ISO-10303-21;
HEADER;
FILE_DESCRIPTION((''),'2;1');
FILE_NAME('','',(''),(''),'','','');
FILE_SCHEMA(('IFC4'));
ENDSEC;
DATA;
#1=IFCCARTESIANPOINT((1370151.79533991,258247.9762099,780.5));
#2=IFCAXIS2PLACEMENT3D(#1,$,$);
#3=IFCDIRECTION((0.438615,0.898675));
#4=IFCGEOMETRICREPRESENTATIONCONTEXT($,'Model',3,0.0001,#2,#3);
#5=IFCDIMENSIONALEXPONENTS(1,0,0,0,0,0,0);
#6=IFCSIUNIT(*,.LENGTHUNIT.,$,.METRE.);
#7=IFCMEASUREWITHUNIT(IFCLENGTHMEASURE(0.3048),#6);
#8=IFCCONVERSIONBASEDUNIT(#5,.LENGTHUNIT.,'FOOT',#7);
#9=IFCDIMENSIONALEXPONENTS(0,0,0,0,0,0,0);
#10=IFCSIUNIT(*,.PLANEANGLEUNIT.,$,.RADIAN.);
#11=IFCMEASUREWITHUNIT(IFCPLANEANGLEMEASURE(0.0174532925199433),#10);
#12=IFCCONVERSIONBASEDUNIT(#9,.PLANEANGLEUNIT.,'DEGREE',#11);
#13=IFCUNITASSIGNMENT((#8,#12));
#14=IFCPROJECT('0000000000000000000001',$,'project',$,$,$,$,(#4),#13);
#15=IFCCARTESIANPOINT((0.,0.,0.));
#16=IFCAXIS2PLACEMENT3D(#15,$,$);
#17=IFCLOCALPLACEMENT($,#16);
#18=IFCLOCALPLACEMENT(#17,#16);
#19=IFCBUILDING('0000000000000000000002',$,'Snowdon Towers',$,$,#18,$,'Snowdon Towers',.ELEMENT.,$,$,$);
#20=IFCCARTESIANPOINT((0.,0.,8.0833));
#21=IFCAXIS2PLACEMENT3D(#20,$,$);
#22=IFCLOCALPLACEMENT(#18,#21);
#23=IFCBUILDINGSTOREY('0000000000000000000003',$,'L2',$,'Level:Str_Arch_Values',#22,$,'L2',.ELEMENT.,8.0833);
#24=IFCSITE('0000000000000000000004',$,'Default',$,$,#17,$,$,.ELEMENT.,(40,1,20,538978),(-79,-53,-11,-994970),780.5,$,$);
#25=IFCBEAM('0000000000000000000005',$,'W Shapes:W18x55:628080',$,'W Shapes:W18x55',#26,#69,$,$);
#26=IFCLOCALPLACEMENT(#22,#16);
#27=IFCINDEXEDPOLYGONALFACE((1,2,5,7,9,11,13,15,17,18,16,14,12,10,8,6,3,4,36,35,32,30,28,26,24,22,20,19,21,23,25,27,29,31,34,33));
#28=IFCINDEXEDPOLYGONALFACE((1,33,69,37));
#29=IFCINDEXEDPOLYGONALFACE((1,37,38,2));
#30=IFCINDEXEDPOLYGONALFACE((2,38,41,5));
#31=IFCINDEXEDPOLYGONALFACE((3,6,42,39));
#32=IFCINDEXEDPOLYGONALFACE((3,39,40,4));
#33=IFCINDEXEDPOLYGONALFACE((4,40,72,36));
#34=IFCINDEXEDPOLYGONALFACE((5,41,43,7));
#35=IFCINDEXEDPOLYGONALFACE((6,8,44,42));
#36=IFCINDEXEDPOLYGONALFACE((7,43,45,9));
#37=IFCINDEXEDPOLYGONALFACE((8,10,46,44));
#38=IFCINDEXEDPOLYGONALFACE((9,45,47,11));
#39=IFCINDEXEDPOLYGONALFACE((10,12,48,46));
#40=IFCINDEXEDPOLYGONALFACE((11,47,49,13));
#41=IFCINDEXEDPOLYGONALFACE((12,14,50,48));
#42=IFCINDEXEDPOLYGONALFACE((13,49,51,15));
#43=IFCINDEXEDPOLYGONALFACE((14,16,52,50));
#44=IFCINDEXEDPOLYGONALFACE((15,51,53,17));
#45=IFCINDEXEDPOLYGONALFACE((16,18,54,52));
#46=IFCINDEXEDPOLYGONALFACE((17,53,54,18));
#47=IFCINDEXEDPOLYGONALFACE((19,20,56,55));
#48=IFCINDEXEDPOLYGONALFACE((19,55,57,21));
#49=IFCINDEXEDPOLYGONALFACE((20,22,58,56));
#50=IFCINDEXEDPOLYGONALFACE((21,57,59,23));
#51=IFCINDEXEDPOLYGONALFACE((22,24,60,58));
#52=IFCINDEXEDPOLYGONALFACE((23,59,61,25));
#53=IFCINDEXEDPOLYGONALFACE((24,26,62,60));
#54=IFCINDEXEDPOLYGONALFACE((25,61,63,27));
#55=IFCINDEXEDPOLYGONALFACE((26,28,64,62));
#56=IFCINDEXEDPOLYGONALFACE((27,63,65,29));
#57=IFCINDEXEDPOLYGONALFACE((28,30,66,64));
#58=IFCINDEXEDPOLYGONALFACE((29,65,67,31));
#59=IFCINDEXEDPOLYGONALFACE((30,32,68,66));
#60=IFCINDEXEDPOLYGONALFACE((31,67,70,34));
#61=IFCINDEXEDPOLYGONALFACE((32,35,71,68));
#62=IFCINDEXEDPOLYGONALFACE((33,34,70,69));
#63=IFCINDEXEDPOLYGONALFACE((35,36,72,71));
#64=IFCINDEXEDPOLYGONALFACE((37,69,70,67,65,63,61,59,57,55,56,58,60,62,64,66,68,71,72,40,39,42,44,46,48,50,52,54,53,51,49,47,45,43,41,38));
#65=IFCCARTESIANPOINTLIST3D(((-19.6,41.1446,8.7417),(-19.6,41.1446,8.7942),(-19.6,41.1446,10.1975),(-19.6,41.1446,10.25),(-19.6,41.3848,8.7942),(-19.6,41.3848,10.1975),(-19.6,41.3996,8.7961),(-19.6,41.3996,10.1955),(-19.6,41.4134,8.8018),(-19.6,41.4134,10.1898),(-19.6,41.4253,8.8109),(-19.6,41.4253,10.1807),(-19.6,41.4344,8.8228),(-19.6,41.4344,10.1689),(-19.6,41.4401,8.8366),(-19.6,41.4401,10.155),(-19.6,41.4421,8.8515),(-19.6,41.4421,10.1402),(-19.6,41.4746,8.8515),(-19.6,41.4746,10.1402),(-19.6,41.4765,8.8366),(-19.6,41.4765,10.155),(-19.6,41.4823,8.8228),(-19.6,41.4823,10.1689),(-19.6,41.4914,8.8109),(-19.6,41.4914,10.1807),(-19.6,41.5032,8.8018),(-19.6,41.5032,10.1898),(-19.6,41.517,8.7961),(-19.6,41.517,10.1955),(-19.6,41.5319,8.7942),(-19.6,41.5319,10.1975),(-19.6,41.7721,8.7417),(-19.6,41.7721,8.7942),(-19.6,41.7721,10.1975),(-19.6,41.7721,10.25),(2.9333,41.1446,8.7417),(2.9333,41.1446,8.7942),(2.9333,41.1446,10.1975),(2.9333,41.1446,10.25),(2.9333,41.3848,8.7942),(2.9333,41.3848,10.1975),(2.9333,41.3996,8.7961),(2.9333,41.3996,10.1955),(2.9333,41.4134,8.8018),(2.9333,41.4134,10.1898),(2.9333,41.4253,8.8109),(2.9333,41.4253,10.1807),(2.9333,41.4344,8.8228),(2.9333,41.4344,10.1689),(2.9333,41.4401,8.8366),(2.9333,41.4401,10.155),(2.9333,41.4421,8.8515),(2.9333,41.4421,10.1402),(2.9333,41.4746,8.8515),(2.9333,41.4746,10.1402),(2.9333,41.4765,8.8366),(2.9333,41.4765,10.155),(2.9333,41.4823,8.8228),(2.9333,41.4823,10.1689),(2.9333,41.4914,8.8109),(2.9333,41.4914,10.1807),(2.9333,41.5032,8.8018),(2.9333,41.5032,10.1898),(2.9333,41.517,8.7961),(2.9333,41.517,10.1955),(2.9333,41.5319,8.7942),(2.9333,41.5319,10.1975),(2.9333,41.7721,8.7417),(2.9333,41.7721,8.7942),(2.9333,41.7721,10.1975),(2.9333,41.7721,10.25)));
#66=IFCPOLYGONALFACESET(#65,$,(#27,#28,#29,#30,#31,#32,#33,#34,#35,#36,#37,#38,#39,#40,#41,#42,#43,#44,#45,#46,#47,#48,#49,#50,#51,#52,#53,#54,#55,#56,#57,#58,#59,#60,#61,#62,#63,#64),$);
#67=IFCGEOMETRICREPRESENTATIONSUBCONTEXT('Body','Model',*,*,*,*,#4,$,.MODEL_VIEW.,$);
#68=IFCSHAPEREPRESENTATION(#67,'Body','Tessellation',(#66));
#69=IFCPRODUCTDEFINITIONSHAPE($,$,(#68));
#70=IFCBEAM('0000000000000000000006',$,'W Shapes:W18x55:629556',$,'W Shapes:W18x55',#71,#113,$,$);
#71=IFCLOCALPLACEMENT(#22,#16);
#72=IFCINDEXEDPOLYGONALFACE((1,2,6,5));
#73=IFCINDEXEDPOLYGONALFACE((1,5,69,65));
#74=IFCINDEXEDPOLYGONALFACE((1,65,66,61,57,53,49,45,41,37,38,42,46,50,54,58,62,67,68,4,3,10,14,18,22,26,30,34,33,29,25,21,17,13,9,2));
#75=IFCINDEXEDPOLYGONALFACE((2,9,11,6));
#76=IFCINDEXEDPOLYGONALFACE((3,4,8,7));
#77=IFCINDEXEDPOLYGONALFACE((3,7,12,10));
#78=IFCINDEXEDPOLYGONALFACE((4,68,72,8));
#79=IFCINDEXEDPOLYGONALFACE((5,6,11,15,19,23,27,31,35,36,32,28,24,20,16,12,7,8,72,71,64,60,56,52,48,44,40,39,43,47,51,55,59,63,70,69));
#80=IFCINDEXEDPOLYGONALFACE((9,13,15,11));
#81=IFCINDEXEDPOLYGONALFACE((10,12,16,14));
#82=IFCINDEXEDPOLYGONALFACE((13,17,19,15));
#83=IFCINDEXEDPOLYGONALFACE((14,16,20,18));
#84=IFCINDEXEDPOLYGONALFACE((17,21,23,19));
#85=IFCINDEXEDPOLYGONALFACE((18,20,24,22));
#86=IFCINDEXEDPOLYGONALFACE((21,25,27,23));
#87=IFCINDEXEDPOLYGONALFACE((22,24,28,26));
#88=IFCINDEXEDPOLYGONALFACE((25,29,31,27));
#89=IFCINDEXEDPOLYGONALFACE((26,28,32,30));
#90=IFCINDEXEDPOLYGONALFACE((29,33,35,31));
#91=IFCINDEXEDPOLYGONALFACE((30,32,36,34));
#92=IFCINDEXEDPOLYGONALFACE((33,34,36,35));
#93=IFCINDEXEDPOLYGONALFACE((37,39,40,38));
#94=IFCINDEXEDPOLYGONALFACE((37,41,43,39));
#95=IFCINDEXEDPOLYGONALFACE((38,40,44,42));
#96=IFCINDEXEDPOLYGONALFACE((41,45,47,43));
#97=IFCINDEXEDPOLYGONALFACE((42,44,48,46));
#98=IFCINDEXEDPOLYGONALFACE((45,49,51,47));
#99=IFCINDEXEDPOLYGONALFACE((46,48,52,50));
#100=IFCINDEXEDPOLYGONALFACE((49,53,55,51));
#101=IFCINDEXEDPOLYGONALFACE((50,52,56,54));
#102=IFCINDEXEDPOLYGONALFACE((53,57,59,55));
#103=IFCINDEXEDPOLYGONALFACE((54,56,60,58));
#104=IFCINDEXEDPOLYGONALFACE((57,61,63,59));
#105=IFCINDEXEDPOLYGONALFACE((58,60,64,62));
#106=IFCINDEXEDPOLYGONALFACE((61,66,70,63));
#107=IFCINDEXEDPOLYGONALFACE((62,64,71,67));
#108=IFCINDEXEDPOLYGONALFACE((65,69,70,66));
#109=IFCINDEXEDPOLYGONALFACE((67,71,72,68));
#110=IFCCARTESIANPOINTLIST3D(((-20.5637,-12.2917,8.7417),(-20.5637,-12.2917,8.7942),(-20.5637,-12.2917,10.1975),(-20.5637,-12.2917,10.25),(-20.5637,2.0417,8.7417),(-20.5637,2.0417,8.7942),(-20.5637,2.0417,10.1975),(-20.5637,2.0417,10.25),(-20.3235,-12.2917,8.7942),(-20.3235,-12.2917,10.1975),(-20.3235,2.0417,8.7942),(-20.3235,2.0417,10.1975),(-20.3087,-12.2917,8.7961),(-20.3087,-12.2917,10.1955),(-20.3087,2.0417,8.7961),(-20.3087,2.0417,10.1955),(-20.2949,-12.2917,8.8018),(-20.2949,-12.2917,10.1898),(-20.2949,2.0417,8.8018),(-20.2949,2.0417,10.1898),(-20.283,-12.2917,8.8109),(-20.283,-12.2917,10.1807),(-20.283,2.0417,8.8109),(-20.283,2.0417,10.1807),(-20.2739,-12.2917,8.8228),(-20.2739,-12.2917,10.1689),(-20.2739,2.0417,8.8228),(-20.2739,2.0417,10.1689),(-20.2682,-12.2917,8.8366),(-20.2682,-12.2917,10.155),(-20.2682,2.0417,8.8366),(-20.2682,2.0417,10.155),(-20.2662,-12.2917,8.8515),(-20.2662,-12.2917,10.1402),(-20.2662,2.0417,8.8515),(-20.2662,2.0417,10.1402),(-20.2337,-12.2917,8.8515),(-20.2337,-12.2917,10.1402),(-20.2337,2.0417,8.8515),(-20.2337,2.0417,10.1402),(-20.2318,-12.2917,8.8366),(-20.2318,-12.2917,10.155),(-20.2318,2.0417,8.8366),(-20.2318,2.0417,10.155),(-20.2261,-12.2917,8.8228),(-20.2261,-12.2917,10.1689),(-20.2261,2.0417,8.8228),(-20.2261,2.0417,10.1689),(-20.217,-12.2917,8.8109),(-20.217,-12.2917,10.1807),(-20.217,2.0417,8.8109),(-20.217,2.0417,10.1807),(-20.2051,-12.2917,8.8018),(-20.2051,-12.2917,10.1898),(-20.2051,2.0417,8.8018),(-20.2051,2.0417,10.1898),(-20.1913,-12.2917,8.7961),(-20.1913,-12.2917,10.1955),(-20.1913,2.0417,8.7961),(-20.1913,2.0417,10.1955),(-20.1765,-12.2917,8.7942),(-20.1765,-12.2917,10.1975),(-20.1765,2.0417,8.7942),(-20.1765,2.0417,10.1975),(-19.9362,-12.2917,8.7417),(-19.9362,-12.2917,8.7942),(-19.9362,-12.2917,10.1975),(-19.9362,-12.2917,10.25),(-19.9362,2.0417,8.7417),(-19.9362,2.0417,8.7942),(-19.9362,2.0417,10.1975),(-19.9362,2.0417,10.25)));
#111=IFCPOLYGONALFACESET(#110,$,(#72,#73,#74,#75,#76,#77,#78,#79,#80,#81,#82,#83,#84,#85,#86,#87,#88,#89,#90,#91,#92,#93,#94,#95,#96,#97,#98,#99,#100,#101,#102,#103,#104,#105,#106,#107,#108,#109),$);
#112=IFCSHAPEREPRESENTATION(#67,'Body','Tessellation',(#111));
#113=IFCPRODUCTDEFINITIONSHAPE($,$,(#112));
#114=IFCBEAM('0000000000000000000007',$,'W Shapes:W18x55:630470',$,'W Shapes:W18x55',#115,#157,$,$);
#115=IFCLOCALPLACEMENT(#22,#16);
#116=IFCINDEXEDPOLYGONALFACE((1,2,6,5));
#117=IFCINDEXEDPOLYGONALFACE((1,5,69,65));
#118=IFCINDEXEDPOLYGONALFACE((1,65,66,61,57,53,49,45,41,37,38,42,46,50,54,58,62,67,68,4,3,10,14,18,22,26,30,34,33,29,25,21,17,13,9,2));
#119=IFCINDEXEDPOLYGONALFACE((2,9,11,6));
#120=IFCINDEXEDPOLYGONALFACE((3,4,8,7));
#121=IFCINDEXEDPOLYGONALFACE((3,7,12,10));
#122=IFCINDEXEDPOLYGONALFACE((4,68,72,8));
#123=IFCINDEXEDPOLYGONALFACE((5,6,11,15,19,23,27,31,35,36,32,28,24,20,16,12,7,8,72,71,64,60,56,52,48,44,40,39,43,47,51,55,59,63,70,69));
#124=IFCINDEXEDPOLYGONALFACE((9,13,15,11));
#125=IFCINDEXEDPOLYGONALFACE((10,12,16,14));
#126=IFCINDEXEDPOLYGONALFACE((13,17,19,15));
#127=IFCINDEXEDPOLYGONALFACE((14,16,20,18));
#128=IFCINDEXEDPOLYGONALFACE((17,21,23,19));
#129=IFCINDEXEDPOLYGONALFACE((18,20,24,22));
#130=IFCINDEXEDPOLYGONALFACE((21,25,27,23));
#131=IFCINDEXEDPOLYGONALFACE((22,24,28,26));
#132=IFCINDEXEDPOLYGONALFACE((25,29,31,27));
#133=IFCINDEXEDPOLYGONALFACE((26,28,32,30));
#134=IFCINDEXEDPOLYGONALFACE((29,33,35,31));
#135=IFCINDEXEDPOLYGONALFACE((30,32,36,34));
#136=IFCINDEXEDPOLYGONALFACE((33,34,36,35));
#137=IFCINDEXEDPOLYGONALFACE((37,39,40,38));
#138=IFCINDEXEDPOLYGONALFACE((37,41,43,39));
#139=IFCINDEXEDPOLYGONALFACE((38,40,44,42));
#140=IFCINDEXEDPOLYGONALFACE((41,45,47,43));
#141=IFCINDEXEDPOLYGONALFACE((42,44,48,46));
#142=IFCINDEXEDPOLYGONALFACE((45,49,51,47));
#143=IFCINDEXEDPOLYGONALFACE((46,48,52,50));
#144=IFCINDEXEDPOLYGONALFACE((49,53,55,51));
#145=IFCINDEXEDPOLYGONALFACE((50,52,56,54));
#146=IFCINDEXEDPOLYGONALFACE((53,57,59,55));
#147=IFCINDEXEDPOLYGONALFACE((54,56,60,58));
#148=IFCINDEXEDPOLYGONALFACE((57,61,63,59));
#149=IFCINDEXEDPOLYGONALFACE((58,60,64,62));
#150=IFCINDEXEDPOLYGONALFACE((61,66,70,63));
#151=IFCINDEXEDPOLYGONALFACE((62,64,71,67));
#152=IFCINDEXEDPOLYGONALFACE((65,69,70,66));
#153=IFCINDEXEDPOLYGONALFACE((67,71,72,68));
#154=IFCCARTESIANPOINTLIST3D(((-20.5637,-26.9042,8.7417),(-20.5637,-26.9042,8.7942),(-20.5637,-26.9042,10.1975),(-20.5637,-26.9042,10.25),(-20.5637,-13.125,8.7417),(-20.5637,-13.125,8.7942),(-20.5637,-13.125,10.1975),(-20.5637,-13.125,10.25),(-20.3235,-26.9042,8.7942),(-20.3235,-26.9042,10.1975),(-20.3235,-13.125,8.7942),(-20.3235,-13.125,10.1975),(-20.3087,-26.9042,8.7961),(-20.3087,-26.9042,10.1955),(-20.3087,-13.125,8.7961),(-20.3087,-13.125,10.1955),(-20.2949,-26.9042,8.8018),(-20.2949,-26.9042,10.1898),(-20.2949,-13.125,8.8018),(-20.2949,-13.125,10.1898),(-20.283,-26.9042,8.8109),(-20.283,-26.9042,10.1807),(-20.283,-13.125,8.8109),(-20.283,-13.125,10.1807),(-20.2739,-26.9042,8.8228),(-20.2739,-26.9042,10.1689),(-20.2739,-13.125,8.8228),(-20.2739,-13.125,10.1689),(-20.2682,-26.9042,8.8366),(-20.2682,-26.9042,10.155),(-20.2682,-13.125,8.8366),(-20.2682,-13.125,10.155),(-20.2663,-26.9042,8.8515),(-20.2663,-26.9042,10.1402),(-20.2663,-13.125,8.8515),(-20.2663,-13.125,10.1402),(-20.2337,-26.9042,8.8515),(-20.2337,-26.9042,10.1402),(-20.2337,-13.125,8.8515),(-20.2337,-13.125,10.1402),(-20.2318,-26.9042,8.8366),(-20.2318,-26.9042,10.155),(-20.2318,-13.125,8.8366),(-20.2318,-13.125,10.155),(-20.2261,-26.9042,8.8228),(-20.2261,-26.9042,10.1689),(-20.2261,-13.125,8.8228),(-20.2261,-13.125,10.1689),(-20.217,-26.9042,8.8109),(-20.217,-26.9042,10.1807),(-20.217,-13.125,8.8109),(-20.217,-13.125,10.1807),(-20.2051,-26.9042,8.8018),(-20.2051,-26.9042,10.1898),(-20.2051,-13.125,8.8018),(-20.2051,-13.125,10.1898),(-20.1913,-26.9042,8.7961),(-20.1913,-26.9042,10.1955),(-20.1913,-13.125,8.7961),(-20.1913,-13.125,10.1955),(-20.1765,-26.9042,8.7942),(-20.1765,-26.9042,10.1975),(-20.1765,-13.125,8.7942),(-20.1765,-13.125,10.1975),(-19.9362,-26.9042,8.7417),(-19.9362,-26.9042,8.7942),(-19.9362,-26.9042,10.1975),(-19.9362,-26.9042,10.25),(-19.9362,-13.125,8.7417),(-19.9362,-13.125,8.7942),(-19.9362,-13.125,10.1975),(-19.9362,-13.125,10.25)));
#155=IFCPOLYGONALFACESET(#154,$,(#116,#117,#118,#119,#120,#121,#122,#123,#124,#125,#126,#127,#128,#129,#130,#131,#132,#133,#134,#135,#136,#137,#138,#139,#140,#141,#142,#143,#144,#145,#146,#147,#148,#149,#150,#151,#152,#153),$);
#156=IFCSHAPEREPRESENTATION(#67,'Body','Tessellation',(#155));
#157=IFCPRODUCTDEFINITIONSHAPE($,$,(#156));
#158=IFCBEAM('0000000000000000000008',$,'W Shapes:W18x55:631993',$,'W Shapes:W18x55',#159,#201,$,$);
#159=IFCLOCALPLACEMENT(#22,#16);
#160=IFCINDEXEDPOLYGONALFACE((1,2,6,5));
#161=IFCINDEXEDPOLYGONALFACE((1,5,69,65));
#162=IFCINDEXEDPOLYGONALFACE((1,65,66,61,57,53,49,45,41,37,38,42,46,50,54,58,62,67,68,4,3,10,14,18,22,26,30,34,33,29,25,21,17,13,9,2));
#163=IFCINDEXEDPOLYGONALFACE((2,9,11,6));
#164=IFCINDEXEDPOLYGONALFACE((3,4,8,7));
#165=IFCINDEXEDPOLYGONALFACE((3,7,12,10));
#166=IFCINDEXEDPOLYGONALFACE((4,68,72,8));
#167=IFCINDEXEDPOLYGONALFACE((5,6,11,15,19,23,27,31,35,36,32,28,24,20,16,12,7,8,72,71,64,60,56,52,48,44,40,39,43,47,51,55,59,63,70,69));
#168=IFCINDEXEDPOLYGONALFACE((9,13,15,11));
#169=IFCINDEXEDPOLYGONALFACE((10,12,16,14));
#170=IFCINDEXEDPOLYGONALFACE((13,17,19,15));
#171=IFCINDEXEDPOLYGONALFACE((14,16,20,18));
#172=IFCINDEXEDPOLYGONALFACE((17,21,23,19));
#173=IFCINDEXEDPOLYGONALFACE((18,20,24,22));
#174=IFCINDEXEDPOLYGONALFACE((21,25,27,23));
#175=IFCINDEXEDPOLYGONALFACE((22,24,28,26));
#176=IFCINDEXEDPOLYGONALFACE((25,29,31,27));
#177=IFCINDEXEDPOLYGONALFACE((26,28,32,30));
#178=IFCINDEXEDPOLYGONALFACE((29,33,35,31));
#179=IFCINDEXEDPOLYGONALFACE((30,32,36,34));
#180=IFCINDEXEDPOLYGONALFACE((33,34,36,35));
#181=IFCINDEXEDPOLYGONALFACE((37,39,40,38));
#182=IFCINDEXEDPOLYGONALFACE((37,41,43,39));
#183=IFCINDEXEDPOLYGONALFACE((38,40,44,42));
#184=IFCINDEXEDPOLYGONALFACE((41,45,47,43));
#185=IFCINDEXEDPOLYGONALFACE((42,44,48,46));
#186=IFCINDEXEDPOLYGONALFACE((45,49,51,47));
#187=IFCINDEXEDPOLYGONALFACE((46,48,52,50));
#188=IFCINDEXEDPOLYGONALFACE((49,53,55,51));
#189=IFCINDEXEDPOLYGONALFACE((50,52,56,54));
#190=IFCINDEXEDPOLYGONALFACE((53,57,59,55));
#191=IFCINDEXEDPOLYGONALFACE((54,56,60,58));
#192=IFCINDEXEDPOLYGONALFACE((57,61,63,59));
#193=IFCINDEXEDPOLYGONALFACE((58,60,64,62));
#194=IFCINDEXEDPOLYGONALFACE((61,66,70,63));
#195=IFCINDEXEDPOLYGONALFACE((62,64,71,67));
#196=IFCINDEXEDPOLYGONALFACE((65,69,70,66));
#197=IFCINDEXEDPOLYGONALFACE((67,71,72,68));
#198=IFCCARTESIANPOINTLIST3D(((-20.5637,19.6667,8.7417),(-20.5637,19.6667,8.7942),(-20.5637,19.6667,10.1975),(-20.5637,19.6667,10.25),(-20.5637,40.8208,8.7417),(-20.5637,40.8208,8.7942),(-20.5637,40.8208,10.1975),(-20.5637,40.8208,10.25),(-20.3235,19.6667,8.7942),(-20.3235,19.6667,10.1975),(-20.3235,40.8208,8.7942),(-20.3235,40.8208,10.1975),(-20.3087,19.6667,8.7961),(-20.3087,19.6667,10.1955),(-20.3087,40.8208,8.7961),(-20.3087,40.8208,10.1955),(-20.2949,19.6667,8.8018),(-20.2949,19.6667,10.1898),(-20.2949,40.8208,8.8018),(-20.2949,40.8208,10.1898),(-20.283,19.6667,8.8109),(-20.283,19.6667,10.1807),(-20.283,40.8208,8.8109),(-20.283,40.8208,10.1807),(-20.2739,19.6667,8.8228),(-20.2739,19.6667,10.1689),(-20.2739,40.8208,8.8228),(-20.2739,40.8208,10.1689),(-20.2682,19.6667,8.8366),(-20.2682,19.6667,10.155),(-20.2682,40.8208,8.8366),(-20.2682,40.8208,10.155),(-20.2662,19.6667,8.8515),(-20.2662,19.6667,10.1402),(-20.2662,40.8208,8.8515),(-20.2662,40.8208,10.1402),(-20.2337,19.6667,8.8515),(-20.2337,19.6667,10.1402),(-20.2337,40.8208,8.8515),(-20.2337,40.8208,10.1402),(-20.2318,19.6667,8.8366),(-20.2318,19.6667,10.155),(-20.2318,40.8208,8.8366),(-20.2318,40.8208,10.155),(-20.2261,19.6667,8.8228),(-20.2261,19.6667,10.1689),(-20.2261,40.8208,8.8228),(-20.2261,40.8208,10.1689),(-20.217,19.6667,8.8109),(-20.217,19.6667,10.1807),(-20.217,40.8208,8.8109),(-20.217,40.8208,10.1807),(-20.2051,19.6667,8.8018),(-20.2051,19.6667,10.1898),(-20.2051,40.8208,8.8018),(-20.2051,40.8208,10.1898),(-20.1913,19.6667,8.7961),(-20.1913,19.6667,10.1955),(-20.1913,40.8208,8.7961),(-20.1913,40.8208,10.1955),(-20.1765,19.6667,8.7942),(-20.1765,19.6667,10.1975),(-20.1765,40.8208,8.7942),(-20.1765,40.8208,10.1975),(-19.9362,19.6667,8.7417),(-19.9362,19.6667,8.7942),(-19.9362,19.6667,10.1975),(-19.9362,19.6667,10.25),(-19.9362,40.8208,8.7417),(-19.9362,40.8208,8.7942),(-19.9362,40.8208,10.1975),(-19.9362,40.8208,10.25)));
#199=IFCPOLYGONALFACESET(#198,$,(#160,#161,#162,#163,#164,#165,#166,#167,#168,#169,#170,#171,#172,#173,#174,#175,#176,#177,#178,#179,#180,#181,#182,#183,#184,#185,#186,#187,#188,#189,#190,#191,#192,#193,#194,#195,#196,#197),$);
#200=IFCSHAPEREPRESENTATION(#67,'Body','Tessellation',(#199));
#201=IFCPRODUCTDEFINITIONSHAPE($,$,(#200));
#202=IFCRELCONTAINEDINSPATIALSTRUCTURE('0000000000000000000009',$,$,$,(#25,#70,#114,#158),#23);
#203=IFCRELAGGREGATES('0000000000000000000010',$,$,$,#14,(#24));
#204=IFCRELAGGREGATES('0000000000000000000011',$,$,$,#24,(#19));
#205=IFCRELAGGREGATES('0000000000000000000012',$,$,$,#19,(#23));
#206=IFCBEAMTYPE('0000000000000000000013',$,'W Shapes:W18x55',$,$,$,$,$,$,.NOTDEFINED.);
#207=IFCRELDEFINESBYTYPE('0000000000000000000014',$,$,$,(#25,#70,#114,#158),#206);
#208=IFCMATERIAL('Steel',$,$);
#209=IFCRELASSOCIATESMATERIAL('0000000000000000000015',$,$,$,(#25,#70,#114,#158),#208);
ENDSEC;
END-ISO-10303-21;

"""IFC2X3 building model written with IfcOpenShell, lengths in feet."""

from ifc_helpers import new_model, entity, si_unit, converted_unit, direction, frame, frame_2d, origin, place, context, subcontext, project, spatial, i_section, extrude, material, type_object, element, save


model = new_model("IFC2X3")

# Units and contexts
model_context = context("Model", 3, precision=0.0001, world=frame((1370151.79533991, 258247.9762099, 780.5)), true_north=direction((0.438615, 0.898675)))
body_context = subcontext(model_context, "Body", "Model", "MODEL_VIEW")
ifc_project = project(units=[converted_unit("LENGTHUNIT", "FOOT", entity("IfcLengthMeasure", 0.3048), si_unit("LENGTHUNIT", "METRE"), dimensions=[1, 0, 0, 0, 0, 0, 0]), converted_unit("PLANEANGLEUNIT", "DEGREE", entity("IfcPlaneAngleMeasure", 0.0174532925199433), si_unit("PLANEANGLEUNIT", "RADIAN"), dimensions=[0, 0, 0, 0, 0, 0, 0])], contexts=[model_context])

# Site, building, storey
site_placement = place(None, origin())
site = spatial("IfcSite", under=ifc_project, at=site_placement, Name="Default", CompositionType="ELEMENT", RefLatitude=(40, 1, 20, 538978), RefLongitude=(-79, -53, -11, -994970), RefElevation=780.5)
building_placement = place(site_placement, origin())
building = spatial("IfcBuilding", under=site, at=building_placement, Name="Snowdon Towers", LongName="Snowdon Towers", CompositionType="ELEMENT")
storey_placement = place(building_placement, frame((0.0, 0.0, 8.0833)))
storey = spatial("IfcBuildingStorey", under=building, at=storey_placement, Name="L2", ObjectType="Level:Str_Arch_Values", LongName="L2", CompositionType="ELEMENT", Elevation=8.0833)

# Beams
ifc_material_1 = material(Name="Steel")
beam_type_1 = type_object("IfcBeamType", Name="W Shapes:W18x55", PredefinedType="NOTDEFINED")
beam_1_placement = place(storey_placement, frame((-20.25, 41.4583, 10.25)))
element("IfcBeam", 1, at=beam_1_placement, inside=storey, type_object=beam_type_1, material=ifc_material_1, Name="W Shapes:W18x55:628080", ObjectType="W Shapes:W18x55", context=body_context, shape_type="SweptSolid", body=[
    extrude(i_section(OverallWidth=0.6275, OverallDepth=1.5083, WebThickness=0.0325, FlangeThickness=0.0525, FilletRadius=0.0573, at=frame_2d((0.0, 0.0), x_axis=(0.0, 1.0))), frame((0.65, 0.0, -0.7542), z_axis=(1.0, 0.0, 0.0), x_axis=(0.0, 0.0, -1.0)), (0.0, 0.0, 1.0), 22.5333),
])
beam_2_placement = place(storey_placement, frame((-20.25, 2.5, 10.25), z_axis=(0.0, 0.0, 1.0), x_axis=(0.0, -1.0, 0.0)))
element("IfcBeam", 2, at=beam_2_placement, inside=storey, type_object=beam_type_1, material=ifc_material_1, Name="W Shapes:W18x55:629556", ObjectType="W Shapes:W18x55", context=body_context, shape_type="SweptSolid", body=[
    extrude(i_section(OverallWidth=0.6275, OverallDepth=1.5083, WebThickness=0.0325, FlangeThickness=0.0525, FilletRadius=0.0573, at=frame_2d((0.0, 0.0), x_axis=(0.0, 1.0))), frame((0.4583, 0.0, -0.7542), z_axis=(1.0, 0.0, 0.0), x_axis=(0.0, 0.0, -1.0)), (0.0, 0.0, 1.0), 14.3333),
])
beam_3_placement = place(storey_placement, frame((-20.25, -12.7083, 10.25), z_axis=(0.0, 0.0, 1.0), x_axis=(0.0, -1.0, 0.0)))
element("IfcBeam", 3, at=beam_3_placement, inside=storey, type_object=beam_type_1, material=ifc_material_1, Name="W Shapes:W18x55:630470", ObjectType="W Shapes:W18x55", context=body_context, shape_type="SweptSolid", body=[
    extrude(i_section(OverallWidth=0.6275, OverallDepth=1.5083, WebThickness=0.0325, FlangeThickness=0.0525, FilletRadius=0.0573, at=frame_2d((0.0, 0.0), x_axis=(0.0, 1.0))), frame((0.4167, 0.0, -0.7542), z_axis=(1.0, 0.0, 0.0), x_axis=(0.0, 0.0, -1.0)), (0.0, 0.0, 1.0), 13.7792),
])
beam_4_placement = place(storey_placement, frame((-20.25, 41.625, 10.25), z_axis=(0.0, 0.0, 1.0), x_axis=(0.0, -1.0, 0.0)))
element("IfcBeam", 4, at=beam_4_placement, inside=storey, type_object=beam_type_1, material=ifc_material_1, Name="W Shapes:W18x55:631993", ObjectType="W Shapes:W18x55", context=body_context, shape_type="SweptSolid", body=[
    extrude(i_section(OverallWidth=0.6275, OverallDepth=1.5083, WebThickness=0.0325, FlangeThickness=0.0525, FilletRadius=0.0573, at=frame_2d((0.0, 0.0), x_axis=(0.0, 1.0))), frame((0.8042, 0.0, -0.7542), z_axis=(1.0, 0.0, 0.0), x_axis=(0.0, 0.0, -1.0)), (0.0, 0.0, 1.0), 21.1542),
])

save(model, "model.ifc")
